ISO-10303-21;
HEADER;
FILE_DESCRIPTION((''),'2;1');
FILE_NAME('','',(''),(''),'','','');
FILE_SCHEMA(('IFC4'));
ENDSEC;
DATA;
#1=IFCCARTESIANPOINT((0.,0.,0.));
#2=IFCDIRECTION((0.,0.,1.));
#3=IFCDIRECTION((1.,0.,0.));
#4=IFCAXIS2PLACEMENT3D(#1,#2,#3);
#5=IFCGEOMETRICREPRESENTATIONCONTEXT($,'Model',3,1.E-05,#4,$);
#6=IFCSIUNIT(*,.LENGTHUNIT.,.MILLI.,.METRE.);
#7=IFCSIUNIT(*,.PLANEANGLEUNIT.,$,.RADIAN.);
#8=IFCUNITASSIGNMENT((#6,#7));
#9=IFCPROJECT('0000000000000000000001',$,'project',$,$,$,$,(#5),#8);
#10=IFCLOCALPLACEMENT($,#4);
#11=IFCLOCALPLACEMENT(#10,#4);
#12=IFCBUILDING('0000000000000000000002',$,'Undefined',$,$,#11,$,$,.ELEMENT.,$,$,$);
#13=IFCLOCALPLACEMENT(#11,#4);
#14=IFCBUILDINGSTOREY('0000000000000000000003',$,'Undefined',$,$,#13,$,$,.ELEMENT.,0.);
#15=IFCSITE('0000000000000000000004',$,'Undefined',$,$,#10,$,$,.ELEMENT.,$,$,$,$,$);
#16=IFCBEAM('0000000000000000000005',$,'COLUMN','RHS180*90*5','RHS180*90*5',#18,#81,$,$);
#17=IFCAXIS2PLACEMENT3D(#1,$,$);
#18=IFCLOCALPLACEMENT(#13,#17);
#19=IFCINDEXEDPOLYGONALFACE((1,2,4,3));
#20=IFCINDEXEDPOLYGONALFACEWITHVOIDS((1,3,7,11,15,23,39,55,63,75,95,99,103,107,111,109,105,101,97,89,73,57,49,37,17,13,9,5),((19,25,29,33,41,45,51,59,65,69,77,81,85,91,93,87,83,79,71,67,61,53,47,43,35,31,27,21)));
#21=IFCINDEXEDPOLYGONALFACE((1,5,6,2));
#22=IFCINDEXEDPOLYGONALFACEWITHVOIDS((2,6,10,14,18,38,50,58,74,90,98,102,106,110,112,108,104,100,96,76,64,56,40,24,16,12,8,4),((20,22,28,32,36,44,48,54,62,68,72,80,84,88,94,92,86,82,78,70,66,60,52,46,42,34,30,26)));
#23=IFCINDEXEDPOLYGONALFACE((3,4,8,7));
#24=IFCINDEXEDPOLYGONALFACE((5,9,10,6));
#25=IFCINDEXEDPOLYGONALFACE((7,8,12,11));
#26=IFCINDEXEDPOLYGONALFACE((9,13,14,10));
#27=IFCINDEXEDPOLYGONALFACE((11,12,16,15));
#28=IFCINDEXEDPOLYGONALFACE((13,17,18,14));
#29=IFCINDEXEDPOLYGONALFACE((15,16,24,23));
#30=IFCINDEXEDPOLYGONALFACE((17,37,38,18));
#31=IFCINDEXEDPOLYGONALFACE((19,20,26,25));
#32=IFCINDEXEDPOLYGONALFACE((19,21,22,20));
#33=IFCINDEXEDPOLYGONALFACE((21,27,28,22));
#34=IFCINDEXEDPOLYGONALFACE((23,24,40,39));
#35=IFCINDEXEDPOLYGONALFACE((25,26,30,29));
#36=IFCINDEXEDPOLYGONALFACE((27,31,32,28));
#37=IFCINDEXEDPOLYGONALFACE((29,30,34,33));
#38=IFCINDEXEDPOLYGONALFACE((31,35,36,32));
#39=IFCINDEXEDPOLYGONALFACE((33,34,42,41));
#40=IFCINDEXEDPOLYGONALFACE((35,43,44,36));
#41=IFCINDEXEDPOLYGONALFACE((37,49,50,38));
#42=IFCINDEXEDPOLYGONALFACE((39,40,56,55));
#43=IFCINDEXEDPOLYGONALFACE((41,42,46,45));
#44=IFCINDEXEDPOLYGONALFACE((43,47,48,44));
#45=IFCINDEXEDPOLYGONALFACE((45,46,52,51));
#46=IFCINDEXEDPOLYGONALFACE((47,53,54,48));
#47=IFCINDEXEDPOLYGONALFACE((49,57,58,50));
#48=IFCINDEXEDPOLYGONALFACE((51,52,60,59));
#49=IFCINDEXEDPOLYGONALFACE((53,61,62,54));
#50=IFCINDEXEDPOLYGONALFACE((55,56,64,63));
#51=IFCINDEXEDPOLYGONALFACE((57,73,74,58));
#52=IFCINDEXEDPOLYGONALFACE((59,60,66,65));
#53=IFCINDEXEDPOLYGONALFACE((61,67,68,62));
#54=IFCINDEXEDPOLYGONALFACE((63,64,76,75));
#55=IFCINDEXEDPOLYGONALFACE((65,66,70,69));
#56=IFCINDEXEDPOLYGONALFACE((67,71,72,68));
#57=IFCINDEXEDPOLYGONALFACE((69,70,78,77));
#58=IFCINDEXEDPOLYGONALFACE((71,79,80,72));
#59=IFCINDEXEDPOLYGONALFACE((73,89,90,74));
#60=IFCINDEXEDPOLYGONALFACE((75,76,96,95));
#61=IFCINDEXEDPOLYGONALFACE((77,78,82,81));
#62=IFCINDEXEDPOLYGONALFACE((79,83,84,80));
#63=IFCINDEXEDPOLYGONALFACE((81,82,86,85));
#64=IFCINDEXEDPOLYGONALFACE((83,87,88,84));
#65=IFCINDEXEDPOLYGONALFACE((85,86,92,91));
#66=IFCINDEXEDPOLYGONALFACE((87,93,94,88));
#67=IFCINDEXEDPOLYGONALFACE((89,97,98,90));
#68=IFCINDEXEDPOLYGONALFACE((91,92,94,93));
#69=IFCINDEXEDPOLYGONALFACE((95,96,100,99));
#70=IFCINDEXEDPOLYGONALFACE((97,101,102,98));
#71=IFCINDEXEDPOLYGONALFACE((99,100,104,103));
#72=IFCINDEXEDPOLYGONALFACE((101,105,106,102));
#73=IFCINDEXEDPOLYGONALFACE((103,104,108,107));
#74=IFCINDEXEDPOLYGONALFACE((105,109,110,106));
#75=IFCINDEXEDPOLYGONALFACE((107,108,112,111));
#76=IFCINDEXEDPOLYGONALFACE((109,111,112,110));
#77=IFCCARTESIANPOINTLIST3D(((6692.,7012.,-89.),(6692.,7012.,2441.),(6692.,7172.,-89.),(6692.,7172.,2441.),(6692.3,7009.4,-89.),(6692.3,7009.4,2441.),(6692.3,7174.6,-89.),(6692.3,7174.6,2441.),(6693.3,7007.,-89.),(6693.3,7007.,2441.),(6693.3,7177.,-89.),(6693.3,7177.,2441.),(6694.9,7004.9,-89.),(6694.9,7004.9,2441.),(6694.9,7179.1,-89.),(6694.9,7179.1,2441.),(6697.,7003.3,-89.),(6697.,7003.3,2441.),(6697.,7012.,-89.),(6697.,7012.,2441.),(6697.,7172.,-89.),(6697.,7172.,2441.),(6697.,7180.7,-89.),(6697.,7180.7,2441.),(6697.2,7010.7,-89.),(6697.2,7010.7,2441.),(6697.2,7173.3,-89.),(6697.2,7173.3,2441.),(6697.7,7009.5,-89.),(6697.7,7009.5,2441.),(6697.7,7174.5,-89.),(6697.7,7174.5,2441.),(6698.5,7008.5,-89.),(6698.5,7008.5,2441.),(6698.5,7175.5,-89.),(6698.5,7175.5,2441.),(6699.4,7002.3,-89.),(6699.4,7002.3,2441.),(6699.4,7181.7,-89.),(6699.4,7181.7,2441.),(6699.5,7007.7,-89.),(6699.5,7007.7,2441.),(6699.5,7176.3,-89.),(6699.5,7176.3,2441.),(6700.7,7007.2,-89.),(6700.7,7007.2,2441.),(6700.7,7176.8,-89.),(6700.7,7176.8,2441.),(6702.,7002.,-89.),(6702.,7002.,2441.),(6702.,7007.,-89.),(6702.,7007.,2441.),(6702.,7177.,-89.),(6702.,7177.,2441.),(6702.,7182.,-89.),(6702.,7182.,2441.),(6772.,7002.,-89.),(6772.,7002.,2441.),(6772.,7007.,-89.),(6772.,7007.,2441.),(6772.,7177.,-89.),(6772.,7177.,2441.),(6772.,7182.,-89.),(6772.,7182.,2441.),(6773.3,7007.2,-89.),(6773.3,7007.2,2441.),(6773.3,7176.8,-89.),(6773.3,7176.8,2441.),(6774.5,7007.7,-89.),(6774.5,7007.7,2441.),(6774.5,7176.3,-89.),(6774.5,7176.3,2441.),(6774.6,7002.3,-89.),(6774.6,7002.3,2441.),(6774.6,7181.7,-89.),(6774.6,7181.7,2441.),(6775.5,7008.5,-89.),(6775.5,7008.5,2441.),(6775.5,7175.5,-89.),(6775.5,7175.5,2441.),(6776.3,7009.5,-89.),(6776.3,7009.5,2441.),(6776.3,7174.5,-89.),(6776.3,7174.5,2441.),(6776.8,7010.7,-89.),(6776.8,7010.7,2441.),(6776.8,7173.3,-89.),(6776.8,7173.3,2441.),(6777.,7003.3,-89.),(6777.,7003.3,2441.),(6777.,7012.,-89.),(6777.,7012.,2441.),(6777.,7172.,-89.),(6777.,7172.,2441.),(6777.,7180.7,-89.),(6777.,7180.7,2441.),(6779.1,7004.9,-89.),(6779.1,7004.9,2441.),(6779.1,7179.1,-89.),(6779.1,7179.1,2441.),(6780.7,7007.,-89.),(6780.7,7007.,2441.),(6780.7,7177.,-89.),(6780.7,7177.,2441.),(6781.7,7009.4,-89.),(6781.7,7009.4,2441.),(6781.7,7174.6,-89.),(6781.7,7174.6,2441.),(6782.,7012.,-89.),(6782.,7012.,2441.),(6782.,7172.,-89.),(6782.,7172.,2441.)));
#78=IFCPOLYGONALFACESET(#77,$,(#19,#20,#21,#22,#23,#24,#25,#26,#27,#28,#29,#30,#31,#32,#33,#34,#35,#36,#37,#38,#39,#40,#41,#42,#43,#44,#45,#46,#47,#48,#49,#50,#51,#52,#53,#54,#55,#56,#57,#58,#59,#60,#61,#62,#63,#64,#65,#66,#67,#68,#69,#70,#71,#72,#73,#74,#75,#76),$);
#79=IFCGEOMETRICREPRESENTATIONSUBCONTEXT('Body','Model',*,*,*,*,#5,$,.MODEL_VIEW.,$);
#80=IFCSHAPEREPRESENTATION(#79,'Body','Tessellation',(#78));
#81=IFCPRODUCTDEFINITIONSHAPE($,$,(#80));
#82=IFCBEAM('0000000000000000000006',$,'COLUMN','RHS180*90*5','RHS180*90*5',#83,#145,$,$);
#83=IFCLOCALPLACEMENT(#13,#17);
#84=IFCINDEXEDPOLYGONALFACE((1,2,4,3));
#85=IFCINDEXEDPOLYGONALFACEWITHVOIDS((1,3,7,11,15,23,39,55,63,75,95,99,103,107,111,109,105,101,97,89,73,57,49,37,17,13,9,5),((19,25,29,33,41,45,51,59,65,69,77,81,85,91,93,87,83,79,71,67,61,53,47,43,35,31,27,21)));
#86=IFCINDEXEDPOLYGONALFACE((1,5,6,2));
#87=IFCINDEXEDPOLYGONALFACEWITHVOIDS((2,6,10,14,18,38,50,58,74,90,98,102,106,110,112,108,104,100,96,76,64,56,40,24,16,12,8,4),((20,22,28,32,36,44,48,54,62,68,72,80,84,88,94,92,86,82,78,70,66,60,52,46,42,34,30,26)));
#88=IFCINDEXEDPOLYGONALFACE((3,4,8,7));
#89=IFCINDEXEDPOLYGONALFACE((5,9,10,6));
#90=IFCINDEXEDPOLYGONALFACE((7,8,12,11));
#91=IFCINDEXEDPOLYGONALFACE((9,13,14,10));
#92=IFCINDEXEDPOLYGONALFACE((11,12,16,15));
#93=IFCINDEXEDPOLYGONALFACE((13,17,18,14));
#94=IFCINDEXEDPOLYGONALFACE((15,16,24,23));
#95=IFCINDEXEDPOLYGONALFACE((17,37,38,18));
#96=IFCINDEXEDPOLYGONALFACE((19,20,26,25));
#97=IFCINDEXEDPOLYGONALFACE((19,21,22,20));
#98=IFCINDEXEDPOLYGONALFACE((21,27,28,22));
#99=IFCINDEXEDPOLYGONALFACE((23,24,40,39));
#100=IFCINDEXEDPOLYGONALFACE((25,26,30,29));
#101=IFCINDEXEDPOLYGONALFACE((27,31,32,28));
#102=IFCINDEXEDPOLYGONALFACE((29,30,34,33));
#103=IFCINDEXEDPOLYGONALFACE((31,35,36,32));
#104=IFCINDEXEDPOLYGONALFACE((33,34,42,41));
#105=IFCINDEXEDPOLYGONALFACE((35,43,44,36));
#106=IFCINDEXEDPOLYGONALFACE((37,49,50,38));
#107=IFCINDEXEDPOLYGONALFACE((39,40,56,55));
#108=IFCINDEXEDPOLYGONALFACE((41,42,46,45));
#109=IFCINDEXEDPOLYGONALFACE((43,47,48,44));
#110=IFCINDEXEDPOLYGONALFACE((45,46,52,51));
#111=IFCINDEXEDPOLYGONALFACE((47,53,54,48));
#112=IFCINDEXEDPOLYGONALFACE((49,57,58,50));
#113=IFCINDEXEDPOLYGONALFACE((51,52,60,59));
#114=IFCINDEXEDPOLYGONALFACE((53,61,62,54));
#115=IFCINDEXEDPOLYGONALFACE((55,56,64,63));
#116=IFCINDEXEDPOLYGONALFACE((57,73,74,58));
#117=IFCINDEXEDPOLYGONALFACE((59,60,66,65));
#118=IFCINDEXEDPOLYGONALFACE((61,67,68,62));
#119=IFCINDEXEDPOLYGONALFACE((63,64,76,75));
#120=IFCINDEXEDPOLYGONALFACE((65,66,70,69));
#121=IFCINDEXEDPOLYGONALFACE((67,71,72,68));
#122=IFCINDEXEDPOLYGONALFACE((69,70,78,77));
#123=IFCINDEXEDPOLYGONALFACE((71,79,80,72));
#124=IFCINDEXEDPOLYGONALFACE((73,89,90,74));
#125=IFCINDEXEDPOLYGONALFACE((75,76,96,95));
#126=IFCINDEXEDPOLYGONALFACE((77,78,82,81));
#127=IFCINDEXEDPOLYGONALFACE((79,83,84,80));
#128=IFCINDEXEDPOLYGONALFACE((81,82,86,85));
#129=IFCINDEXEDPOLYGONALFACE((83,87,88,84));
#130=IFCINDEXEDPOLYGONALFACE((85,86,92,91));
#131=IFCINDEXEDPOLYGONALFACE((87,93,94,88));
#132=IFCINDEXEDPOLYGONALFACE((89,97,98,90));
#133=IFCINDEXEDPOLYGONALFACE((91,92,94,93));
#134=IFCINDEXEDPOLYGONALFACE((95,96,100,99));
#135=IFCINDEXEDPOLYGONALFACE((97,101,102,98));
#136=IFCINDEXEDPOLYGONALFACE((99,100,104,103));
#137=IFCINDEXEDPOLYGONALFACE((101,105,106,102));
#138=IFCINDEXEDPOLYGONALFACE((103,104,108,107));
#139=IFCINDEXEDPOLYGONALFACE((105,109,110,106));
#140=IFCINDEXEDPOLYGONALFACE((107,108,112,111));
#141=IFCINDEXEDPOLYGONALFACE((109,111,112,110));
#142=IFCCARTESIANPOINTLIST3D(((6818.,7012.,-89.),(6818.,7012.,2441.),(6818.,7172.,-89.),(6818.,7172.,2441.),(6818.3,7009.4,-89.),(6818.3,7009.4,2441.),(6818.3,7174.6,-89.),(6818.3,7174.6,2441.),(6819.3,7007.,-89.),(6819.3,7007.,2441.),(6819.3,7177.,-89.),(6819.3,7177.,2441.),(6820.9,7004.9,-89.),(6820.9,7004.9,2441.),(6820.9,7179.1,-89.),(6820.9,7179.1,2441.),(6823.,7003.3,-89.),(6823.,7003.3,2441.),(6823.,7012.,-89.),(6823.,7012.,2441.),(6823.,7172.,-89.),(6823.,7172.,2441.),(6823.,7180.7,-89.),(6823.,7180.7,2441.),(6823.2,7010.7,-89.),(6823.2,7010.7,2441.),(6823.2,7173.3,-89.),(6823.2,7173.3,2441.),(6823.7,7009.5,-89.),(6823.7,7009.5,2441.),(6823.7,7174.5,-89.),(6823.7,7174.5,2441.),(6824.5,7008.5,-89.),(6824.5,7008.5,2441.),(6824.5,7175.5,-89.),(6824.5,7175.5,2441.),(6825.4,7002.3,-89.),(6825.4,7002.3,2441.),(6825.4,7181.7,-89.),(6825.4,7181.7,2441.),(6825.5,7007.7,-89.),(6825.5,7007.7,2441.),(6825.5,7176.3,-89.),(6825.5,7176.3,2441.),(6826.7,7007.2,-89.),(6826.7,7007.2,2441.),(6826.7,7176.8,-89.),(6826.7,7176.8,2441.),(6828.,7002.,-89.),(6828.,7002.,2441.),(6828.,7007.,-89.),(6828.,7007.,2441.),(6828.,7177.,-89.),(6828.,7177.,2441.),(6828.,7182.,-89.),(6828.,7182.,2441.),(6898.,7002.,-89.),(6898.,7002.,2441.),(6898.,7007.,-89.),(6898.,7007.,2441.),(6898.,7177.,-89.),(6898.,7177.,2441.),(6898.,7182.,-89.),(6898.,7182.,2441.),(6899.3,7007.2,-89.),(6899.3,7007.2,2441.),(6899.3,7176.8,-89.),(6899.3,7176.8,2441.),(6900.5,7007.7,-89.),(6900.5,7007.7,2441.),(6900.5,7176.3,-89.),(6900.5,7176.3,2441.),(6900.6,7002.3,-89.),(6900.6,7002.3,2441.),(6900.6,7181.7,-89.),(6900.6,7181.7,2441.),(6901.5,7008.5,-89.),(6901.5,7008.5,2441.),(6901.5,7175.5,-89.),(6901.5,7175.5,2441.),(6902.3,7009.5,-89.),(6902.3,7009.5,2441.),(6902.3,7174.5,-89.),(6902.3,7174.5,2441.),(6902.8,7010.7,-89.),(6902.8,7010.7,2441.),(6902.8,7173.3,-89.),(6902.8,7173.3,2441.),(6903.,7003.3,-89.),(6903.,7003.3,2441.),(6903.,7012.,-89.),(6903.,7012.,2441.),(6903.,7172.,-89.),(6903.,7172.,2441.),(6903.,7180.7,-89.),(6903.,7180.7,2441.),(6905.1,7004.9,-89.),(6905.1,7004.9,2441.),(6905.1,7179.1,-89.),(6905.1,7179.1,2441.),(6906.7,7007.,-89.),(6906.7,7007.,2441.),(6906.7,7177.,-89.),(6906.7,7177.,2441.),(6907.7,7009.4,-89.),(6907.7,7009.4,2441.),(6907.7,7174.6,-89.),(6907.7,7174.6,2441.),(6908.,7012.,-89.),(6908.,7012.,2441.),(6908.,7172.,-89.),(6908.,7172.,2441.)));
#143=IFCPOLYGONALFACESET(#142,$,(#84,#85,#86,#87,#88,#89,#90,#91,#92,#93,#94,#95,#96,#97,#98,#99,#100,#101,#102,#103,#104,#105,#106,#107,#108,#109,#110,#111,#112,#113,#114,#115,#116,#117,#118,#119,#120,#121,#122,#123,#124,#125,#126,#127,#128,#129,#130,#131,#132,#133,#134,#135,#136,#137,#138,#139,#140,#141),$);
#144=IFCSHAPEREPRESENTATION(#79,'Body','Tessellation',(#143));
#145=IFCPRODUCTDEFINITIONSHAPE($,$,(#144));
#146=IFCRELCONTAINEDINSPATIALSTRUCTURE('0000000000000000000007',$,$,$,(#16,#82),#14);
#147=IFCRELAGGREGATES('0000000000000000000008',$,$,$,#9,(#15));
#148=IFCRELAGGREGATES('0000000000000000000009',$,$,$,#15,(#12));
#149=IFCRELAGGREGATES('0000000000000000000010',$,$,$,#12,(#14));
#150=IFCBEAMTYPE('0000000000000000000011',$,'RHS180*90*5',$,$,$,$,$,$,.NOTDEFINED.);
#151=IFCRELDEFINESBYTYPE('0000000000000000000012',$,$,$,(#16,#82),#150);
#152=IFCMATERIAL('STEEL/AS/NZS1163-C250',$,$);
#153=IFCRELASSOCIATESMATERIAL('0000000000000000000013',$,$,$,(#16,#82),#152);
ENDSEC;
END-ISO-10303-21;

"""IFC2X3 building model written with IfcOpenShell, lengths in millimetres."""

from ifc_helpers import new_model, si_unit, frame, origin_with_axes, origin_2d_with_axis, place, context, subcontext, project, spatial, hollow_rectangle, extrude, material, type_object, element, save


model = new_model("IFC2X3")

# Units and contexts
model_context = context("Model", 3, precision=1e-05, world=origin_with_axes())
body_context = subcontext(model_context, "Body", "Model", "MODEL_VIEW")
ifc_project = project(units=[si_unit("LENGTHUNIT", "METRE", prefix="MILLI"), si_unit("PLANEANGLEUNIT", "RADIAN")], contexts=[model_context])

# Site, building, storey
site_placement = place(None, origin_with_axes())
site = spatial("IfcSite", under=ifc_project, at=site_placement, Name="Undefined", CompositionType="ELEMENT")
building_placement = place(site_placement, origin_with_axes())
building = spatial("IfcBuilding", under=site, at=building_placement, Name="Undefined", CompositionType="ELEMENT")
storey_placement = place(building_placement, origin_with_axes())
storey = spatial("IfcBuildingStorey", under=building, at=storey_placement, Name="Undefined", CompositionType="ELEMENT", Elevation=0.0)

# Shared definitions
ifc_material_1 = material(Name="STEEL/AS/NZS1163-C250")

# Beams
beam_type_1 = type_object("IfcBeamType", Name="RHS180*90*5", PredefinedType="NOTDEFINED")
for number, where, z_axis, x_axis, name in (
    (1, (6737.0, 7092.0, 2441.0), (0.0, 1.0, 0.0), (0.0, 0.0, -1.0), "COLUMN"),
    (2, (6863.0, 7092.0, 2441.0), (0.0, 1.0, 0.0), (0.0, 0.0, -1.0), "COLUMN"),
):
    element("IfcBeam", number, at=place(storey_placement, frame(where, z_axis=z_axis, x_axis=x_axis)), inside=storey, type_object=beam_type_1, material=ifc_material_1, Name=name, Description="RHS180*90*5", ObjectType="RHS180*90*5", context=body_context, shape_type="SweptSolid", body=[
        extrude(hollow_rectangle(XDim=90.0, YDim=180.0, WallThickness=5.0, InnerFilletRadius=5.0, OuterFilletRadius=10.0, at=origin_2d_with_axis()), frame((2530.0, 0.0, 0.0), z_axis=(-1.0, 0.0, 0.0), x_axis=(0.0, -1.0, 0.0)), (0.0, 0.0, 1.0), 2530.0),
    ])

save(model, "model.ifc")
